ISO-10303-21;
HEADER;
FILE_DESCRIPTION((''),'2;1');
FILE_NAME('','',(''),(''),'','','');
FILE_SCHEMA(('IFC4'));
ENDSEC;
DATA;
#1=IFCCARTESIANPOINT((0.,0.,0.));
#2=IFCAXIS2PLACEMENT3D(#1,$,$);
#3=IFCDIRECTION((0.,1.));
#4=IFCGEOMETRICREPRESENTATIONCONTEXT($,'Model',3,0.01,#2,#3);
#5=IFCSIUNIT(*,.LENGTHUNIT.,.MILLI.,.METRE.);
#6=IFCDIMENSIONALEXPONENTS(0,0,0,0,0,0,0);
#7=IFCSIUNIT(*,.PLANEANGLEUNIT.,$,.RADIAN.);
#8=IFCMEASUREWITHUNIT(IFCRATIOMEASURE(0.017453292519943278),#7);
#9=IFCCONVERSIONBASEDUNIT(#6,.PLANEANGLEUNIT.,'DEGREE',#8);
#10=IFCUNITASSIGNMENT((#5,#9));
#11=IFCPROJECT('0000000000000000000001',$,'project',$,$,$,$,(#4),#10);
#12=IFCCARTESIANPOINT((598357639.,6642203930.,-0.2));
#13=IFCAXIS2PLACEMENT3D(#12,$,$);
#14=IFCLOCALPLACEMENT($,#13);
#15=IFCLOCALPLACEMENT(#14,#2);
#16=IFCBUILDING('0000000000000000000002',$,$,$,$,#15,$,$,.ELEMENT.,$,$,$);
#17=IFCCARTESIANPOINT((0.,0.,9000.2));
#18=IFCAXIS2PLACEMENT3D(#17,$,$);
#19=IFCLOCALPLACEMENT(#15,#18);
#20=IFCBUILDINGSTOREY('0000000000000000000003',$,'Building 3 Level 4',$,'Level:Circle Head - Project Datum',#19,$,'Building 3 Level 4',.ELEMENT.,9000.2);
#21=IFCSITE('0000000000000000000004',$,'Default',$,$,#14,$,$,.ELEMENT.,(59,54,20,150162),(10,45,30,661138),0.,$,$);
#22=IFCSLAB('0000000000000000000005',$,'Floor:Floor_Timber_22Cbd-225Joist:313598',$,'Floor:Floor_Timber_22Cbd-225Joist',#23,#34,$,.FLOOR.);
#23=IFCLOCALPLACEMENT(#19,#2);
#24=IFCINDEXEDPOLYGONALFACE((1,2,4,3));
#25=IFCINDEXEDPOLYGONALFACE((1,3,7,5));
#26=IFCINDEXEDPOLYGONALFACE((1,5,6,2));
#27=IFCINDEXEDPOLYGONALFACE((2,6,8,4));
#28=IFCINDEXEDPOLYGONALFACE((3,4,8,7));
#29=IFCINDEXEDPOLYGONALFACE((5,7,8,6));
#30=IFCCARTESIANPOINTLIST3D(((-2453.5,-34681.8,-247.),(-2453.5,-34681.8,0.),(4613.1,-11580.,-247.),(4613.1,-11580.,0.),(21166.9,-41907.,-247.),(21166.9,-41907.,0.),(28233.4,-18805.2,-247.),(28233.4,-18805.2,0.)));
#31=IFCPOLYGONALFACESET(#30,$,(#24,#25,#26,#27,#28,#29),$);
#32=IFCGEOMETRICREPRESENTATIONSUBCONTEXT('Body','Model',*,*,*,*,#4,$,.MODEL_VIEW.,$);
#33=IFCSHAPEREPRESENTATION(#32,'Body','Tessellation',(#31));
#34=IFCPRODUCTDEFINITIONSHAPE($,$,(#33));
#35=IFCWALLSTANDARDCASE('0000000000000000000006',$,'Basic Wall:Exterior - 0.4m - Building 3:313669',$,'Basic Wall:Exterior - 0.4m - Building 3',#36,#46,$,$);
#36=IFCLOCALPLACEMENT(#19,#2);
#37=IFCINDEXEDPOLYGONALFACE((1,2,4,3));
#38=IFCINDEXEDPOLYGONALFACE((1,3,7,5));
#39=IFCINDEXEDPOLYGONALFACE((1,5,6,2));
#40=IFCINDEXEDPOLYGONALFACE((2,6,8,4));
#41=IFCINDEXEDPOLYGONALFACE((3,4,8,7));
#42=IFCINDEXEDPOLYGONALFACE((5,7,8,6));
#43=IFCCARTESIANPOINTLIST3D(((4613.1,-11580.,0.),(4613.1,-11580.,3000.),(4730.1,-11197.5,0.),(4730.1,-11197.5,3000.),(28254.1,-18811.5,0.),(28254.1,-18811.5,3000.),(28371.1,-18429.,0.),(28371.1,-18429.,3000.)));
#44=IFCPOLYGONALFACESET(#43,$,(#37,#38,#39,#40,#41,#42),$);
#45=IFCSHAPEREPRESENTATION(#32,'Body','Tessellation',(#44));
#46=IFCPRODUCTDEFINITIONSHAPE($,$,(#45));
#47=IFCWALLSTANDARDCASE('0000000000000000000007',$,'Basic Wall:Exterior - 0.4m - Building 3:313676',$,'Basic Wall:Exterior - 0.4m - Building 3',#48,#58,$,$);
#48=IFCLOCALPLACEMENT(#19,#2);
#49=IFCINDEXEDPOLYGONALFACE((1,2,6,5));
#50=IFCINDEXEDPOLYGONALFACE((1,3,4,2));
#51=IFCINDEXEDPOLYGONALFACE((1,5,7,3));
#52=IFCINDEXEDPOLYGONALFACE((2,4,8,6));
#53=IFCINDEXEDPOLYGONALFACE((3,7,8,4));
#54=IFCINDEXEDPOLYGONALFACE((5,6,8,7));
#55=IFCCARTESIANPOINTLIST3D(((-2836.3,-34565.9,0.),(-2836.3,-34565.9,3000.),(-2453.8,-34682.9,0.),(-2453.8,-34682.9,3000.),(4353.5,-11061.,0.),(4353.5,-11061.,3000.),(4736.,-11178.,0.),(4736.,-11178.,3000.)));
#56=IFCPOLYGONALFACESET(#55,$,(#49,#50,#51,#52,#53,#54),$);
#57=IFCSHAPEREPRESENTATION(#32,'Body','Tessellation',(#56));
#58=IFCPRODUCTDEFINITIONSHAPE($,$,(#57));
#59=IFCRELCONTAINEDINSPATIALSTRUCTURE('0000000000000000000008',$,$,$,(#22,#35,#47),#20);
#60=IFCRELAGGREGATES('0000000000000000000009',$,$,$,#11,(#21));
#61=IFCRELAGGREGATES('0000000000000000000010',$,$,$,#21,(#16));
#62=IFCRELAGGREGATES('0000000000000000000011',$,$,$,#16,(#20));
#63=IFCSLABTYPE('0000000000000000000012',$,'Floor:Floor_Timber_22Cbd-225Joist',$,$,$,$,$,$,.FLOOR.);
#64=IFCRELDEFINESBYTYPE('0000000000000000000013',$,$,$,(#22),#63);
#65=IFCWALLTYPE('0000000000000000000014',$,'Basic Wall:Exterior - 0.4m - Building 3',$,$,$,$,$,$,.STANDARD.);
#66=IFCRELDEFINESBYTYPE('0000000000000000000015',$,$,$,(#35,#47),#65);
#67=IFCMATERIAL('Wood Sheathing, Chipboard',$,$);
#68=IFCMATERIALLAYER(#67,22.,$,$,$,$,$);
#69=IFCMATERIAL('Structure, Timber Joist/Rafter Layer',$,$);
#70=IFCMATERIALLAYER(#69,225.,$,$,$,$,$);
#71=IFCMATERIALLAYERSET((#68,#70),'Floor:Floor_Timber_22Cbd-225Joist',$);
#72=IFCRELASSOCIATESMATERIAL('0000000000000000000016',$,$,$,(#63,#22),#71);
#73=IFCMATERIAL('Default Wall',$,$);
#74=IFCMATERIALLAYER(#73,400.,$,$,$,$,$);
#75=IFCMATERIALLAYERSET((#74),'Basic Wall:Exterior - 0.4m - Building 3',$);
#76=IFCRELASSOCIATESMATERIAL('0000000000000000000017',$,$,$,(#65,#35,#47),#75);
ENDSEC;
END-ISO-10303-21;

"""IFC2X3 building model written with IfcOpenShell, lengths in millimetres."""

from ifc_helpers import new_model, entity, si_unit, converted_unit, direction, frame, frame_2d, origin, place, context, subcontext, project, spatial, rectangle, extrude, material, layer, layer_set, layer_usage, type_object, element, save


model = new_model("IFC2X3")

# Units and contexts
model_context = context("Model", 3, precision=0.01, world=origin(), true_north=direction((0.0, 1.0)))
body_context = subcontext(model_context, "Body", "Model", "MODEL_VIEW")
ifc_project = project(units=[si_unit("LENGTHUNIT", "METRE", prefix="MILLI"), converted_unit("PLANEANGLEUNIT", "DEGREE", entity("IfcRatioMeasure", 0.017453292519943278), si_unit("PLANEANGLEUNIT", "RADIAN"), dimensions=[0, 0, 0, 0, 0, 0, 0])], contexts=[model_context])

# Site, building, storey
site_placement = place(None, frame((598357639.0, 6642203930.0, -0.2)))
site = spatial("IfcSite", under=ifc_project, at=site_placement, Name="Default", CompositionType="ELEMENT", RefLatitude=(59, 54, 20, 150162), RefLongitude=(10, 45, 30, 661138), RefElevation=0.0)
building_placement = place(site_placement, origin())
building = spatial("IfcBuilding", under=site, at=building_placement, CompositionType="ELEMENT")
storey_placement = place(building_placement, frame((0.0, 0.0, 9000.2)))
storey = spatial("IfcBuildingStorey", under=building, at=storey_placement, Name="Building 3 Level 4", ObjectType="Level:Circle Head - Project Datum", LongName="Building 3 Level 4", CompositionType="ELEMENT", Elevation=9000.2)

# Slab
ifc_material_1 = material(Name="Wood Sheathing, Chipboard")
ifc_layer_1 = layer(ifc_material_1, 22.0)
ifc_material_2 = material(Name="Structure, Timber Joist/Rafter Layer")
ifc_layer_2 = layer(ifc_material_2, 225.0)
ifc_layer_set_1 = layer_set([ifc_layer_1, ifc_layer_2], Name="Floor:Floor_Timber_22Cbd-225Joist")
ifc_layer_usage_1 = layer_usage(ifc_layer_set_1, "AXIS3", "POSITIVE", 0.0)
slab_type = type_object("IfcSlabType", Name="Floor:Floor_Timber_22Cbd-225Joist", PredefinedType="FLOOR", material=ifc_layer_set_1)
slab_placement = place(storey_placement, origin())
element("IfcSlab", 1, at=slab_placement, inside=storey, type_object=slab_type, material=ifc_layer_usage_1, Name="Floor:Floor_Timber_22Cbd-225Joist:313598", ObjectType="Floor:Floor_Timber_22Cbd-225Joist", PredefinedType="FLOOR", context=body_context, shape_type="SweptSolid", body=[
    extrude(rectangle(XDim=24158.4, YDim=24700.7, at=frame_2d((0.0, 0.0), x_axis=(1.0, 0.0))), frame((12890.0, -26743.5, 0.0), z_axis=(0.0, 0.0, -1.0), x_axis=(-0.292509, -0.956263, 0.0)), (0.0, 0.0, 1.0), 247.0),
])

# Walls
ifc_material_3 = material(Name="Default Wall")
ifc_layer_3 = layer(ifc_material_3, 400.0)
ifc_layer_set_2 = layer_set([ifc_layer_3], Name="Basic Wall:Exterior - 0.4m - Building 3")
ifc_layer_usage_2 = layer_usage(ifc_layer_set_2, "AXIS2", "POSITIVE", -200.0)
wall_type = type_object("IfcWallType", Name="Basic Wall:Exterior - 0.4m - Building 3", PredefinedType="STANDARD", material=ifc_layer_set_2)
wall_1_placement = place(storey_placement, frame((28312.6, -18620.3, 0.0), z_axis=(0.0, 0.0, 1.0), x_axis=(-0.956263, 0.292509, 0.0)))
element("IfcWallStandardCase", 2, at=wall_1_placement, inside=storey, type_object=wall_type, material=ifc_layer_usage_2, Name="Basic Wall:Exterior - 0.4m - Building 3:313669", ObjectType="Basic Wall:Exterior - 0.4m - Building 3", context=body_context, shape_type="SweptSolid", body=[
    extrude(rectangle(XDim=24722.3, YDim=400.0, at=frame_2d((12361.2, 0.0), x_axis=(-1.0, 0.0))), origin(), (0.0, 0.0, 1.0), 3000.0),
])
wall_2_placement = place(storey_placement, frame((4544.8, -11119.5, 0.0), z_axis=(0.0, 0.0, 1.0), x_axis=(-0.292509, -0.956263, 0.0)))
element("IfcWallStandardCase", 3, at=wall_2_placement, inside=storey, type_object=wall_type, material=ifc_layer_usage_2, Name="Basic Wall:Exterior - 0.4m - Building 3:313676", ObjectType="Basic Wall:Exterior - 0.4m - Building 3", context=body_context, shape_type="SweptSolid", body=[
    extrude(rectangle(XDim=24580.0, YDim=400.0, at=frame_2d((12290.0, 0.0), x_axis=(-1.0, 0.0))), origin(), (0.0, 0.0, 1.0), 3000.0),
])

save(model, "model.ifc")
